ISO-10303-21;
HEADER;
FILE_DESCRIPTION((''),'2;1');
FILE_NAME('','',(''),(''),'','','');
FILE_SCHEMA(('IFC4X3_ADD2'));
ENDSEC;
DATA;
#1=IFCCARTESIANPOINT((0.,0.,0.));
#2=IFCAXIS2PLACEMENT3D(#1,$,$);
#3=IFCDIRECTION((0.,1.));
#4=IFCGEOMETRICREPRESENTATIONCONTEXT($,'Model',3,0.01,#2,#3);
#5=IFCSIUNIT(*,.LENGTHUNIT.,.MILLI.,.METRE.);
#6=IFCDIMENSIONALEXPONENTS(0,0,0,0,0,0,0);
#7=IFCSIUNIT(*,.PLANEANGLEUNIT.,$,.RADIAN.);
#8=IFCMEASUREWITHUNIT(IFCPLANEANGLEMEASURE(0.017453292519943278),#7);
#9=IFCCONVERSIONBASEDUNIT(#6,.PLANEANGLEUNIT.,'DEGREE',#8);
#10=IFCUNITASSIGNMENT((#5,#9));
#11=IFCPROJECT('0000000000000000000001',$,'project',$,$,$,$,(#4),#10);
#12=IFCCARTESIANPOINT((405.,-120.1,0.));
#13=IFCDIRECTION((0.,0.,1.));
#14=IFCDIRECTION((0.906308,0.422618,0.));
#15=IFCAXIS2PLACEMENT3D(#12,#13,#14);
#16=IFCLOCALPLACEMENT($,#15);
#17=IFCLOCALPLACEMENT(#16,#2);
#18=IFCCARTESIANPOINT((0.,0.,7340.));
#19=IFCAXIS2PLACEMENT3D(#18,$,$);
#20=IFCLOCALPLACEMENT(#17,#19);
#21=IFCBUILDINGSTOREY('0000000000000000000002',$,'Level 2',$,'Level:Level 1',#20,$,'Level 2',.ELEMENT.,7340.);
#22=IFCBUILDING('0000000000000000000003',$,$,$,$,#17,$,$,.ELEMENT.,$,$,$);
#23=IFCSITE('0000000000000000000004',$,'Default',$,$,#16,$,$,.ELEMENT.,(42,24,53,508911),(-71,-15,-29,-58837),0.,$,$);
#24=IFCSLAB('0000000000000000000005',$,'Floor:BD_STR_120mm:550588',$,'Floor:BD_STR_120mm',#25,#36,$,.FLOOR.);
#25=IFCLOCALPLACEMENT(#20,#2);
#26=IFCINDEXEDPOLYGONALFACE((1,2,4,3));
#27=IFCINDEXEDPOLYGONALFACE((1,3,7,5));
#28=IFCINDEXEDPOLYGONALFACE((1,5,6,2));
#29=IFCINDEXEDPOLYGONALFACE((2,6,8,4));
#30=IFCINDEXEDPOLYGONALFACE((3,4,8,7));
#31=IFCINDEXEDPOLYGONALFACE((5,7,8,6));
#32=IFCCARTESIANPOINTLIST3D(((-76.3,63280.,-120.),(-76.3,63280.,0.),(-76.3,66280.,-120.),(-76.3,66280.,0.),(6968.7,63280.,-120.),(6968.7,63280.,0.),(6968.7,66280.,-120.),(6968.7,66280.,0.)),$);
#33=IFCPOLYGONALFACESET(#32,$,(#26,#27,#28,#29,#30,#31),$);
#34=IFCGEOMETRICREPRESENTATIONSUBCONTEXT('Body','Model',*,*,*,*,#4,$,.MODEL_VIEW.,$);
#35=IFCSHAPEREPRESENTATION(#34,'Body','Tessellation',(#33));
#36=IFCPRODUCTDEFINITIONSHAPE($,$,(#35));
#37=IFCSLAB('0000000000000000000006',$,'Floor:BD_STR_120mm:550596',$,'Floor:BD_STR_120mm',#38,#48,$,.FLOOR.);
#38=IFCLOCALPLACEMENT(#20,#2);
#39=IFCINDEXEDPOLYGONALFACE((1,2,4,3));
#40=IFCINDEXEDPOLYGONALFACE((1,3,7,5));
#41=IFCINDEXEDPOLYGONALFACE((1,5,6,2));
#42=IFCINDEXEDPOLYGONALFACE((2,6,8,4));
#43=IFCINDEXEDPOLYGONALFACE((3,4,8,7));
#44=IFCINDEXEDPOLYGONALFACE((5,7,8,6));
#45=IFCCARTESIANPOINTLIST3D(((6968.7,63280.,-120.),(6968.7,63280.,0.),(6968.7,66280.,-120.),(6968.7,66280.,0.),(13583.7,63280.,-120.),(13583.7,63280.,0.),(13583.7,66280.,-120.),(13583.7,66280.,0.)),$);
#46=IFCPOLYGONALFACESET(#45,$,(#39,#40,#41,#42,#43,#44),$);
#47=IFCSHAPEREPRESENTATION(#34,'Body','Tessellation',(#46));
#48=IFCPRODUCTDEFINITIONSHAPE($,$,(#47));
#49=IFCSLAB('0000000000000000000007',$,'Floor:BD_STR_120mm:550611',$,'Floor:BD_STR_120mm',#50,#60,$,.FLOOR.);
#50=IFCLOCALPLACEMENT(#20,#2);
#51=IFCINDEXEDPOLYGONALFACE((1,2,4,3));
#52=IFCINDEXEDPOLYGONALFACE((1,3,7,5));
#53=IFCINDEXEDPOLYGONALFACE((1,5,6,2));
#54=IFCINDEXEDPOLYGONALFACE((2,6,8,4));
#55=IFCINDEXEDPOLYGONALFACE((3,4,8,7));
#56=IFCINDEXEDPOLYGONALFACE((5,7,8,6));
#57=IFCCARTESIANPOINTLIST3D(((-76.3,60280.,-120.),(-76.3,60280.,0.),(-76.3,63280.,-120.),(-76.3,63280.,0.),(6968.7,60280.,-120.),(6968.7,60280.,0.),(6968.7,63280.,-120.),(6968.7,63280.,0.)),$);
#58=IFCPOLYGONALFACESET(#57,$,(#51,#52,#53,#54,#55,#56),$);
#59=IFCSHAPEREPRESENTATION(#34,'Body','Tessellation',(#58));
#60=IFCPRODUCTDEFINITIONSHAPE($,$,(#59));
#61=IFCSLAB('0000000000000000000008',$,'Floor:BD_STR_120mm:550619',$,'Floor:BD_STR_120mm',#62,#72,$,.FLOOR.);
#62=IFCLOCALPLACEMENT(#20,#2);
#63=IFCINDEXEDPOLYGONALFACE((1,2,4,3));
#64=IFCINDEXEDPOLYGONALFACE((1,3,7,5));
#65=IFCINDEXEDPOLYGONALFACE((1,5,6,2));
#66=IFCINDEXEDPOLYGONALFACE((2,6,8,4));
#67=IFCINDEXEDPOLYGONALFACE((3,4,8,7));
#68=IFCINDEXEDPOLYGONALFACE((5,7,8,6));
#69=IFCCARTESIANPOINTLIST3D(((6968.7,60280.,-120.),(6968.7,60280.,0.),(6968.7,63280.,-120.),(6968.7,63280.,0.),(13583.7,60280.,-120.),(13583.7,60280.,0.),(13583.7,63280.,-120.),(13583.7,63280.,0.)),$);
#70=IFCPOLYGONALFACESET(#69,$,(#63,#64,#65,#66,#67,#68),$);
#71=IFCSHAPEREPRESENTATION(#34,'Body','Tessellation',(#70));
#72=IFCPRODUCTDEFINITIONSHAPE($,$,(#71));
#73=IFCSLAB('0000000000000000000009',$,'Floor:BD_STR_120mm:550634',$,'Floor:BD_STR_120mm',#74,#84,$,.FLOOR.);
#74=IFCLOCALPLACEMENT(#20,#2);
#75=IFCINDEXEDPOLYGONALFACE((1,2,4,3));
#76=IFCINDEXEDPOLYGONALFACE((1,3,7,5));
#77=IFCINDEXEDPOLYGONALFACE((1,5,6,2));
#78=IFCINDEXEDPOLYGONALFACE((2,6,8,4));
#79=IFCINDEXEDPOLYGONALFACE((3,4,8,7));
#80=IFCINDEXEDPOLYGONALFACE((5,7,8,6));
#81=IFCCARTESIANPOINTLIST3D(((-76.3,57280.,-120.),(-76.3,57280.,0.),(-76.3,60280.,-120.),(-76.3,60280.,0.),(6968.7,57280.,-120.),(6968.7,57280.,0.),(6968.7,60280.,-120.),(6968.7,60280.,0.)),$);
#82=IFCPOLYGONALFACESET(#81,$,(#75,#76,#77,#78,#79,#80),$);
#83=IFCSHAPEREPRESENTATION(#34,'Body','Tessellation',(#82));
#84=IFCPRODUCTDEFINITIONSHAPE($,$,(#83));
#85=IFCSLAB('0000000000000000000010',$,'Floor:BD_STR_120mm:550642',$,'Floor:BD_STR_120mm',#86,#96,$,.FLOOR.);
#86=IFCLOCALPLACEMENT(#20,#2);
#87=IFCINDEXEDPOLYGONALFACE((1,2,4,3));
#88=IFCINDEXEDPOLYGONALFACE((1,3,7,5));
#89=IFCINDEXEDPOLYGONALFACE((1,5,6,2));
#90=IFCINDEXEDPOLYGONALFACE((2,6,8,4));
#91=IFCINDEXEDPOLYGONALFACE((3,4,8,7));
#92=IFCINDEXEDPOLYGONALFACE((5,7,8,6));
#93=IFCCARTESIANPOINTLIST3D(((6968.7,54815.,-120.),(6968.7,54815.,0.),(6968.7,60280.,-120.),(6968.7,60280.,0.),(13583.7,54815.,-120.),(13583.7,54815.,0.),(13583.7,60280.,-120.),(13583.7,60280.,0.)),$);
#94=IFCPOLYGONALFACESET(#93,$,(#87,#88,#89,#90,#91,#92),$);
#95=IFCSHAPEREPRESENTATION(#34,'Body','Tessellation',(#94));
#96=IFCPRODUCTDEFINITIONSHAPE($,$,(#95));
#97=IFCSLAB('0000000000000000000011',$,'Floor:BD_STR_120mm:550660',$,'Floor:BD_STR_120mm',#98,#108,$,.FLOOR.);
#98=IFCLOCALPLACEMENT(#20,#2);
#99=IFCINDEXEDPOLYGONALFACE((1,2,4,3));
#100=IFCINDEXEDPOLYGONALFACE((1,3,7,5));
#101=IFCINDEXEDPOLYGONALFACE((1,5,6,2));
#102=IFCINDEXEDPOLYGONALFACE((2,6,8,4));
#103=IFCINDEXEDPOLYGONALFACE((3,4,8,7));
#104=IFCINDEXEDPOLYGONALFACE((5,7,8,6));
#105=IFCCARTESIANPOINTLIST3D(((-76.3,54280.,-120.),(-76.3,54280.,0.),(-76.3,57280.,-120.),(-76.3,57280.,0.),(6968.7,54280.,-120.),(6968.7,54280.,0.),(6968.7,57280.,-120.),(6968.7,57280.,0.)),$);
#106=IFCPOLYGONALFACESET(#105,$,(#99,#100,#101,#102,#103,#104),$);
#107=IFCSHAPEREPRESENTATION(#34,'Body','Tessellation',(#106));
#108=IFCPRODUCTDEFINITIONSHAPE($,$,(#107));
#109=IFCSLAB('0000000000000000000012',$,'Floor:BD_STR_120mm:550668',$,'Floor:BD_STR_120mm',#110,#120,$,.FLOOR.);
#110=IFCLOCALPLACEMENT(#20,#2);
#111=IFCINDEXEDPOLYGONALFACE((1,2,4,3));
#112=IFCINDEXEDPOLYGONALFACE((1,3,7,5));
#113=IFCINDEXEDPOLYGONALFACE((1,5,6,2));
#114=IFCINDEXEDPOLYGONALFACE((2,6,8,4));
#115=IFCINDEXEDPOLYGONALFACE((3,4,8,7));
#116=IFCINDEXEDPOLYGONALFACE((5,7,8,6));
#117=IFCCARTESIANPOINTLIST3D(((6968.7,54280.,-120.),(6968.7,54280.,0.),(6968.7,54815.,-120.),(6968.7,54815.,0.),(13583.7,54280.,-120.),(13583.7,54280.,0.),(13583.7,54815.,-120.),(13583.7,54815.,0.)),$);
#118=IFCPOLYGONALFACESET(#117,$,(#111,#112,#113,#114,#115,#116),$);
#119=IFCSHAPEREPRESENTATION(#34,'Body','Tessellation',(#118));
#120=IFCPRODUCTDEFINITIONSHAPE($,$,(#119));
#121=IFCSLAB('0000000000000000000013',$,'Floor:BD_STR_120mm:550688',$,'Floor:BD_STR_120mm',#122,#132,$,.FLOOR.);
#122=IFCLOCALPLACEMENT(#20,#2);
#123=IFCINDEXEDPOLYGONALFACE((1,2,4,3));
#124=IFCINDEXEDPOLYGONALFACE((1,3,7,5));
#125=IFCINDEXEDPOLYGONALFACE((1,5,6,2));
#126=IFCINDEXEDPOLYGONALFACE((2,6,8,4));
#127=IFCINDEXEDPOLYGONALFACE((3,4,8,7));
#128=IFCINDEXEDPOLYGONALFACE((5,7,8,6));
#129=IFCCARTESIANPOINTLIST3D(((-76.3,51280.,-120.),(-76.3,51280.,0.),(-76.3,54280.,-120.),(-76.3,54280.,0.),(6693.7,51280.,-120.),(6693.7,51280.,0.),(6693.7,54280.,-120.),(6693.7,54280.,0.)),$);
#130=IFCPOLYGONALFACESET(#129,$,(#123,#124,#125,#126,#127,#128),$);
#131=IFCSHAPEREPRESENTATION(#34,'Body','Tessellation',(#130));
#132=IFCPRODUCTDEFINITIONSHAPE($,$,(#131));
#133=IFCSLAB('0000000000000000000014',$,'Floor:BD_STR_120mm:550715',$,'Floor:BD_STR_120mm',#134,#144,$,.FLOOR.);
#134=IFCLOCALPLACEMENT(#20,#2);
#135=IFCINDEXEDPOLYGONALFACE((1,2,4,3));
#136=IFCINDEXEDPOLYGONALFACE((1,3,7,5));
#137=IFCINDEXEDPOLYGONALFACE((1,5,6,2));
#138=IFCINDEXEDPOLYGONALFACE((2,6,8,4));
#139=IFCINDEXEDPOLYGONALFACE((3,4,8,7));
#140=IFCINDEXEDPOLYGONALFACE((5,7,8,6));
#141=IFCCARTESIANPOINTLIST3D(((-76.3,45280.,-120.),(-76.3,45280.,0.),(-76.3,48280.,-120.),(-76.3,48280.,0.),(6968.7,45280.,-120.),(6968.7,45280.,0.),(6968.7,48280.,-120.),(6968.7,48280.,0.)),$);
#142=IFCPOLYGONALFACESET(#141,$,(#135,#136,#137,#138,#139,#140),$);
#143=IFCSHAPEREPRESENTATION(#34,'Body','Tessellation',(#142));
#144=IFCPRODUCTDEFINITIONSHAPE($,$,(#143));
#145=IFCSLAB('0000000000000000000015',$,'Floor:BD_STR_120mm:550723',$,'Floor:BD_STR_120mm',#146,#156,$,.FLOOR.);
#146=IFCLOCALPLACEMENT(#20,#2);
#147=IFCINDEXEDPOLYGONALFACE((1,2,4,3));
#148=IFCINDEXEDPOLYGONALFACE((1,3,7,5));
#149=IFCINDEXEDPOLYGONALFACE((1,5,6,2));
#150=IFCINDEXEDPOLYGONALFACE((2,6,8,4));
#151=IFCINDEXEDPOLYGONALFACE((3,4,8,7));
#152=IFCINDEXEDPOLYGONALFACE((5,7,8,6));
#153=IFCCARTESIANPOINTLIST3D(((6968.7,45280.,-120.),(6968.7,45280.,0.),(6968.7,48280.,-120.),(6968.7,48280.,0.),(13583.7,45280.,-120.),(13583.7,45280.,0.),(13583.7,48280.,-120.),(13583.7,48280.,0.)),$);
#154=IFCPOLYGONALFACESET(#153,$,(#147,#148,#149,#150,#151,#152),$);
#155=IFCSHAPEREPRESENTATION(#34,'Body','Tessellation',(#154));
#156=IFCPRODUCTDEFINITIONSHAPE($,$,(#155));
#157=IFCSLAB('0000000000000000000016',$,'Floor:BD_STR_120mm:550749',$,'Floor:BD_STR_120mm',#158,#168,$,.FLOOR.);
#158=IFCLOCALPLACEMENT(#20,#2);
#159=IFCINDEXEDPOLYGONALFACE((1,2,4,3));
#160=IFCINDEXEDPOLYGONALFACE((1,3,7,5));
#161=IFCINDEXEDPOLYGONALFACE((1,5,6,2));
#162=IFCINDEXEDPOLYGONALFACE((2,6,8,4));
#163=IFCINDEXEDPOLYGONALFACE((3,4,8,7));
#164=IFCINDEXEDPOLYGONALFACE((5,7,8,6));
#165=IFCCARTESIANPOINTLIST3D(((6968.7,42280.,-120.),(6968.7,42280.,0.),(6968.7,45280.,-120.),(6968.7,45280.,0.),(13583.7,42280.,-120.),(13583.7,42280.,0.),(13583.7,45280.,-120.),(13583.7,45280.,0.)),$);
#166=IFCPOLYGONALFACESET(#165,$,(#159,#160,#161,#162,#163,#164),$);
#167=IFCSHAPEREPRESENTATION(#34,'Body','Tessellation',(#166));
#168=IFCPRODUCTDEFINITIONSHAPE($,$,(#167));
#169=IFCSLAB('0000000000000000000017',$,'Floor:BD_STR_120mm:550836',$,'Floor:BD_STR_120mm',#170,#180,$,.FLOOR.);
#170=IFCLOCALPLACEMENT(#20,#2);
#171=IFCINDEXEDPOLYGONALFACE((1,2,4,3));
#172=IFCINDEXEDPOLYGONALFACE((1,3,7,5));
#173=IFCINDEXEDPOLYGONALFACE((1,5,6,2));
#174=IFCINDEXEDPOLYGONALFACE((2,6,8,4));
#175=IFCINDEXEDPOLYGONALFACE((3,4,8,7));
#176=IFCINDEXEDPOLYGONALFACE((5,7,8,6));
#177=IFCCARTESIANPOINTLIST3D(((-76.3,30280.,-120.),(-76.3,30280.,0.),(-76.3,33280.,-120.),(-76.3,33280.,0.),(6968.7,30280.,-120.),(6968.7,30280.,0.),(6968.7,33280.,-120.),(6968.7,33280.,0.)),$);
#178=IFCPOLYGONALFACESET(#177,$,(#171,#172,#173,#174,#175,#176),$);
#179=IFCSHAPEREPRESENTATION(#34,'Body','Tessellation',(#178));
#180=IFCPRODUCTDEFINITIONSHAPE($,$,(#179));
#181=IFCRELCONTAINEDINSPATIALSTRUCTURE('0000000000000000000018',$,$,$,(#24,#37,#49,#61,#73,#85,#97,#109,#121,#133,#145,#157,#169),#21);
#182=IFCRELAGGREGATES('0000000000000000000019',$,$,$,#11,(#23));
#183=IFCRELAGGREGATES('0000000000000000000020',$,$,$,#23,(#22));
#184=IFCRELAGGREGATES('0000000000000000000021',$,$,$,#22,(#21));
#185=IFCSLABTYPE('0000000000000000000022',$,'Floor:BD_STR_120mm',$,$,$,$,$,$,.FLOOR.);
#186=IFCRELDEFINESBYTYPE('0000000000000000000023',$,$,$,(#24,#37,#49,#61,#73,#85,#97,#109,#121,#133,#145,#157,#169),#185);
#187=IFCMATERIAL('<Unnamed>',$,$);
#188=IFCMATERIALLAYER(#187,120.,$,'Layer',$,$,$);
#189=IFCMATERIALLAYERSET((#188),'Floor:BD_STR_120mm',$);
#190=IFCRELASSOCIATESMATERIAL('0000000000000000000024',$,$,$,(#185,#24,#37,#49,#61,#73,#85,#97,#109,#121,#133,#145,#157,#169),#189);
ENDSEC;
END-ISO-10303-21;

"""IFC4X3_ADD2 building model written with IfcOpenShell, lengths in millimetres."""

from ifc_helpers import new_model, entity, si_unit, converted_unit, direction, frame, frame_2d, origin, origin_2d_with_axis, place, context, subcontext, project, spatial, rectangle, extrude, material, layer, layer_set, layer_usage, type_object, element, save


model = new_model("IFC4X3_ADD2")

# Units and contexts
model_context = context("Model", 3, precision=0.01, world=origin(), true_north=direction((0.0, 1.0)))
body_context = subcontext(model_context, "Body", "Model", "MODEL_VIEW")
ifc_project = project(units=[si_unit("LENGTHUNIT", "METRE", prefix="MILLI"), converted_unit("PLANEANGLEUNIT", "DEGREE", entity("IfcPlaneAngleMeasure", 0.017453292519943278), si_unit("PLANEANGLEUNIT", "RADIAN"), dimensions=[0, 0, 0, 0, 0, 0, 0])], contexts=[model_context])

# Site, building, storey
site_placement = place(None, frame((405.0, -120.1, 0.0), z_axis=(0.0, 0.0, 1.0), x_axis=(0.906308, 0.422618, 0.0)))
site = spatial("IfcSite", under=ifc_project, at=site_placement, Name="Default", CompositionType="ELEMENT", RefLatitude=(42, 24, 53, 508911), RefLongitude=(-71, -15, -29, -58837), RefElevation=0.0)
building_placement = place(site_placement, origin())
building = spatial("IfcBuilding", under=site, at=building_placement, CompositionType="ELEMENT")
storey_placement = place(building_placement, frame((0.0, 0.0, 7340.0)))
storey = spatial("IfcBuildingStorey", under=building, at=storey_placement, Name="Level 2", ObjectType="Level:Level 1", LongName="Level 2", CompositionType="ELEMENT", Elevation=7340.0)

# Slabs
ifc_material = material(Name="<Unnamed>")
ifc_layer = layer(ifc_material, 120.0, Name="Layer")
ifc_layer_set = layer_set([ifc_layer], Name="Floor:BD_STR_120mm")
ifc_layer_usage_1 = layer_usage(ifc_layer_set, "AXIS3", "POSITIVE", 0.0)
slab_type = type_object("IfcSlabType", Name="Floor:BD_STR_120mm", PredefinedType="FLOOR", material=ifc_layer_set)
slab_1_placement = place(storey_placement, origin())
element("IfcSlab", 1, at=slab_1_placement, inside=storey, type_object=slab_type, material=ifc_layer_usage_1, Name="Floor:BD_STR_120mm:550588", ObjectType="Floor:BD_STR_120mm", PredefinedType="FLOOR", context=body_context, shape_type="SweptSolid", body=[
    extrude(rectangle(XDim=3000.0, YDim=7045.0, at=frame_2d((0.0, 0.0), x_axis=(1.0, 0.0))), frame((3446.2, 64780.0, 0.0), z_axis=(0.0, 0.0, -1.0), x_axis=(0.0, 1.0, 0.0)), (0.0, 0.0, 1.0), 120.0),
])
ifc_layer_usage_2 = layer_usage(ifc_layer_set, "AXIS3", "POSITIVE", 0.0)
slab_2_placement = place(storey_placement, origin())
element("IfcSlab", 2, at=slab_2_placement, inside=storey, type_object=slab_type, material=ifc_layer_usage_2, Name="Floor:BD_STR_120mm:550596", ObjectType="Floor:BD_STR_120mm", PredefinedType="FLOOR", context=body_context, shape_type="SweptSolid", body=[
    extrude(rectangle(XDim=3000.0, YDim=6615.0, at=frame_2d((0.0, 0.0), x_axis=(1.0, 0.0))), frame((10276.2, 64780.0, 0.0), z_axis=(0.0, 0.0, -1.0), x_axis=(0.0, 1.0, 0.0)), (0.0, 0.0, 1.0), 120.0),
])
ifc_layer_usage_3 = layer_usage(ifc_layer_set, "AXIS3", "POSITIVE", 0.0)
slab_3_placement = place(storey_placement, origin())
element("IfcSlab", 3, at=slab_3_placement, inside=storey, type_object=slab_type, material=ifc_layer_usage_3, Name="Floor:BD_STR_120mm:550611", ObjectType="Floor:BD_STR_120mm", PredefinedType="FLOOR", context=body_context, shape_type="SweptSolid", body=[
    extrude(rectangle(XDim=3000.0, YDim=7045.0, at=frame_2d((0.0, 0.0), x_axis=(1.0, 0.0))), frame((3446.2, 61780.0, 0.0), z_axis=(0.0, 0.0, -1.0), x_axis=(0.0, 1.0, 0.0)), (0.0, 0.0, 1.0), 120.0),
])
ifc_layer_usage_4 = layer_usage(ifc_layer_set, "AXIS3", "POSITIVE", 0.0)
slab_4_placement = place(storey_placement, origin())
element("IfcSlab", 4, at=slab_4_placement, inside=storey, type_object=slab_type, material=ifc_layer_usage_4, Name="Floor:BD_STR_120mm:550619", ObjectType="Floor:BD_STR_120mm", PredefinedType="FLOOR", context=body_context, shape_type="SweptSolid", body=[
    extrude(rectangle(XDim=3000.0, YDim=6615.0, at=frame_2d((0.0, 0.0), x_axis=(1.0, 0.0))), frame((10276.2, 61780.0, 0.0), z_axis=(0.0, 0.0, -1.0), x_axis=(0.0, 1.0, 0.0)), (0.0, 0.0, 1.0), 120.0),
])
ifc_layer_usage_5 = layer_usage(ifc_layer_set, "AXIS3", "POSITIVE", 0.0)
slab_5_placement = place(storey_placement, origin())
element("IfcSlab", 5, at=slab_5_placement, inside=storey, type_object=slab_type, material=ifc_layer_usage_5, Name="Floor:BD_STR_120mm:550634", ObjectType="Floor:BD_STR_120mm", PredefinedType="FLOOR", context=body_context, shape_type="SweptSolid", body=[
    extrude(rectangle(XDim=3000.0, YDim=7045.0, at=frame_2d((0.0, 0.0), x_axis=(1.0, 0.0))), frame((3446.2, 58780.0, 0.0), z_axis=(0.0, 0.0, -1.0), x_axis=(0.0, 1.0, 0.0)), (0.0, 0.0, 1.0), 120.0),
])
ifc_layer_usage_6 = layer_usage(ifc_layer_set, "AXIS3", "POSITIVE", 0.0)
slab_6_placement = place(storey_placement, origin())
element("IfcSlab", 6, at=slab_6_placement, inside=storey, type_object=slab_type, material=ifc_layer_usage_6, Name="Floor:BD_STR_120mm:550642", ObjectType="Floor:BD_STR_120mm", PredefinedType="FLOOR", context=body_context, shape_type="SweptSolid", body=[
    extrude(rectangle(XDim=5465.0, YDim=6615.0, at=frame_2d((0.0, 0.0), x_axis=(1.0, 0.0))), frame((10276.2, 57547.5, 0.0), z_axis=(0.0, 0.0, -1.0), x_axis=(0.0, 1.0, 0.0)), (0.0, 0.0, 1.0), 120.0),
])
ifc_layer_usage_7 = layer_usage(ifc_layer_set, "AXIS3", "POSITIVE", 0.0)
slab_7_placement = place(storey_placement, origin())
element("IfcSlab", 7, at=slab_7_placement, inside=storey, type_object=slab_type, material=ifc_layer_usage_7, Name="Floor:BD_STR_120mm:550660", ObjectType="Floor:BD_STR_120mm", PredefinedType="FLOOR", context=body_context, shape_type="SweptSolid", body=[
    extrude(rectangle(XDim=3000.0, YDim=7045.0, at=origin_2d_with_axis()), frame((3446.2, 55780.0, 0.0), z_axis=(0.0, 0.0, -1.0), x_axis=(0.0, 1.0, 0.0)), (0.0, 0.0, 1.0), 120.0),
])
ifc_layer_usage_8 = layer_usage(ifc_layer_set, "AXIS3", "POSITIVE", 0.0)
slab_8_placement = place(storey_placement, origin())
element("IfcSlab", 8, at=slab_8_placement, inside=storey, type_object=slab_type, material=ifc_layer_usage_8, Name="Floor:BD_STR_120mm:550668", ObjectType="Floor:BD_STR_120mm", PredefinedType="FLOOR", context=body_context, shape_type="SweptSolid", body=[
    extrude(rectangle(XDim=535.0, YDim=6615.0, at=frame_2d((0.0, 0.0), x_axis=(1.0, 0.0))), frame((10276.2, 54547.5, 0.0), z_axis=(0.0, 0.0, -1.0), x_axis=(0.0, 1.0, 0.0)), (0.0, 0.0, 1.0), 120.0),
])
ifc_layer_usage_9 = layer_usage(ifc_layer_set, "AXIS3", "POSITIVE", 0.0)
slab_9_placement = place(storey_placement, origin())
element("IfcSlab", 9, at=slab_9_placement, inside=storey, type_object=slab_type, material=ifc_layer_usage_9, Name="Floor:BD_STR_120mm:550688", ObjectType="Floor:BD_STR_120mm", PredefinedType="FLOOR", context=body_context, shape_type="SweptSolid", body=[
    extrude(rectangle(XDim=3000.0, YDim=6770.0, at=frame_2d((0.0, 0.0), x_axis=(1.0, 0.0))), frame((3308.7, 52780.0, 0.0), z_axis=(0.0, 0.0, -1.0), x_axis=(0.0, 1.0, 0.0)), (0.0, 0.0, 1.0), 120.0),
])
ifc_layer_usage_10 = layer_usage(ifc_layer_set, "AXIS3", "POSITIVE", 0.0)
slab_10_placement = place(storey_placement, origin())
element("IfcSlab", 10, at=slab_10_placement, inside=storey, type_object=slab_type, material=ifc_layer_usage_10, Name="Floor:BD_STR_120mm:550715", ObjectType="Floor:BD_STR_120mm", PredefinedType="FLOOR", context=body_context, shape_type="SweptSolid", body=[
    extrude(rectangle(XDim=3000.0, YDim=7045.0, at=frame_2d((0.0, 0.0), x_axis=(1.0, 0.0))), frame((3446.2, 46780.0, 0.0), z_axis=(0.0, 0.0, -1.0), x_axis=(0.0, 1.0, 0.0)), (0.0, 0.0, 1.0), 120.0),
])
ifc_layer_usage_11 = layer_usage(ifc_layer_set, "AXIS3", "POSITIVE", 0.0)
slab_11_placement = place(storey_placement, origin())
element("IfcSlab", 11, at=slab_11_placement, inside=storey, type_object=slab_type, material=ifc_layer_usage_11, Name="Floor:BD_STR_120mm:550723", ObjectType="Floor:BD_STR_120mm", PredefinedType="FLOOR", context=body_context, shape_type="SweptSolid", body=[
    extrude(rectangle(XDim=3000.0, YDim=6615.0, at=frame_2d((0.0, 0.0), x_axis=(1.0, 0.0))), frame((10276.2, 46780.0, 0.0), z_axis=(0.0, 0.0, -1.0), x_axis=(0.0, 1.0, 0.0)), (0.0, 0.0, 1.0), 120.0),
])
ifc_layer_usage_12 = layer_usage(ifc_layer_set, "AXIS3", "POSITIVE", 0.0)
slab_12_placement = place(storey_placement, origin())
element("IfcSlab", 12, at=slab_12_placement, inside=storey, type_object=slab_type, material=ifc_layer_usage_12, Name="Floor:BD_STR_120mm:550749", ObjectType="Floor:BD_STR_120mm", PredefinedType="FLOOR", context=body_context, shape_type="SweptSolid", body=[
    extrude(rectangle(XDim=3000.0, YDim=6615.0, at=frame_2d((0.0, 0.0), x_axis=(1.0, 0.0))), frame((10276.2, 43780.0, 0.0), z_axis=(0.0, 0.0, -1.0), x_axis=(0.0, 1.0, 0.0)), (0.0, 0.0, 1.0), 120.0),
])
ifc_layer_usage_13 = layer_usage(ifc_layer_set, "AXIS3", "POSITIVE", 0.0)
slab_13_placement = place(storey_placement, origin())
element("IfcSlab", 13, at=slab_13_placement, inside=storey, type_object=slab_type, material=ifc_layer_usage_13, Name="Floor:BD_STR_120mm:550836", ObjectType="Floor:BD_STR_120mm", PredefinedType="FLOOR", context=body_context, shape_type="SweptSolid", body=[
    extrude(rectangle(XDim=3000.0, YDim=7045.0, at=origin_2d_with_axis()), frame((3446.2, 31780.0, 0.0), z_axis=(0.0, 0.0, -1.0), x_axis=(0.0, 1.0, 0.0)), (0.0, 0.0, 1.0), 120.0),
])

save(model, "model.ifc")
